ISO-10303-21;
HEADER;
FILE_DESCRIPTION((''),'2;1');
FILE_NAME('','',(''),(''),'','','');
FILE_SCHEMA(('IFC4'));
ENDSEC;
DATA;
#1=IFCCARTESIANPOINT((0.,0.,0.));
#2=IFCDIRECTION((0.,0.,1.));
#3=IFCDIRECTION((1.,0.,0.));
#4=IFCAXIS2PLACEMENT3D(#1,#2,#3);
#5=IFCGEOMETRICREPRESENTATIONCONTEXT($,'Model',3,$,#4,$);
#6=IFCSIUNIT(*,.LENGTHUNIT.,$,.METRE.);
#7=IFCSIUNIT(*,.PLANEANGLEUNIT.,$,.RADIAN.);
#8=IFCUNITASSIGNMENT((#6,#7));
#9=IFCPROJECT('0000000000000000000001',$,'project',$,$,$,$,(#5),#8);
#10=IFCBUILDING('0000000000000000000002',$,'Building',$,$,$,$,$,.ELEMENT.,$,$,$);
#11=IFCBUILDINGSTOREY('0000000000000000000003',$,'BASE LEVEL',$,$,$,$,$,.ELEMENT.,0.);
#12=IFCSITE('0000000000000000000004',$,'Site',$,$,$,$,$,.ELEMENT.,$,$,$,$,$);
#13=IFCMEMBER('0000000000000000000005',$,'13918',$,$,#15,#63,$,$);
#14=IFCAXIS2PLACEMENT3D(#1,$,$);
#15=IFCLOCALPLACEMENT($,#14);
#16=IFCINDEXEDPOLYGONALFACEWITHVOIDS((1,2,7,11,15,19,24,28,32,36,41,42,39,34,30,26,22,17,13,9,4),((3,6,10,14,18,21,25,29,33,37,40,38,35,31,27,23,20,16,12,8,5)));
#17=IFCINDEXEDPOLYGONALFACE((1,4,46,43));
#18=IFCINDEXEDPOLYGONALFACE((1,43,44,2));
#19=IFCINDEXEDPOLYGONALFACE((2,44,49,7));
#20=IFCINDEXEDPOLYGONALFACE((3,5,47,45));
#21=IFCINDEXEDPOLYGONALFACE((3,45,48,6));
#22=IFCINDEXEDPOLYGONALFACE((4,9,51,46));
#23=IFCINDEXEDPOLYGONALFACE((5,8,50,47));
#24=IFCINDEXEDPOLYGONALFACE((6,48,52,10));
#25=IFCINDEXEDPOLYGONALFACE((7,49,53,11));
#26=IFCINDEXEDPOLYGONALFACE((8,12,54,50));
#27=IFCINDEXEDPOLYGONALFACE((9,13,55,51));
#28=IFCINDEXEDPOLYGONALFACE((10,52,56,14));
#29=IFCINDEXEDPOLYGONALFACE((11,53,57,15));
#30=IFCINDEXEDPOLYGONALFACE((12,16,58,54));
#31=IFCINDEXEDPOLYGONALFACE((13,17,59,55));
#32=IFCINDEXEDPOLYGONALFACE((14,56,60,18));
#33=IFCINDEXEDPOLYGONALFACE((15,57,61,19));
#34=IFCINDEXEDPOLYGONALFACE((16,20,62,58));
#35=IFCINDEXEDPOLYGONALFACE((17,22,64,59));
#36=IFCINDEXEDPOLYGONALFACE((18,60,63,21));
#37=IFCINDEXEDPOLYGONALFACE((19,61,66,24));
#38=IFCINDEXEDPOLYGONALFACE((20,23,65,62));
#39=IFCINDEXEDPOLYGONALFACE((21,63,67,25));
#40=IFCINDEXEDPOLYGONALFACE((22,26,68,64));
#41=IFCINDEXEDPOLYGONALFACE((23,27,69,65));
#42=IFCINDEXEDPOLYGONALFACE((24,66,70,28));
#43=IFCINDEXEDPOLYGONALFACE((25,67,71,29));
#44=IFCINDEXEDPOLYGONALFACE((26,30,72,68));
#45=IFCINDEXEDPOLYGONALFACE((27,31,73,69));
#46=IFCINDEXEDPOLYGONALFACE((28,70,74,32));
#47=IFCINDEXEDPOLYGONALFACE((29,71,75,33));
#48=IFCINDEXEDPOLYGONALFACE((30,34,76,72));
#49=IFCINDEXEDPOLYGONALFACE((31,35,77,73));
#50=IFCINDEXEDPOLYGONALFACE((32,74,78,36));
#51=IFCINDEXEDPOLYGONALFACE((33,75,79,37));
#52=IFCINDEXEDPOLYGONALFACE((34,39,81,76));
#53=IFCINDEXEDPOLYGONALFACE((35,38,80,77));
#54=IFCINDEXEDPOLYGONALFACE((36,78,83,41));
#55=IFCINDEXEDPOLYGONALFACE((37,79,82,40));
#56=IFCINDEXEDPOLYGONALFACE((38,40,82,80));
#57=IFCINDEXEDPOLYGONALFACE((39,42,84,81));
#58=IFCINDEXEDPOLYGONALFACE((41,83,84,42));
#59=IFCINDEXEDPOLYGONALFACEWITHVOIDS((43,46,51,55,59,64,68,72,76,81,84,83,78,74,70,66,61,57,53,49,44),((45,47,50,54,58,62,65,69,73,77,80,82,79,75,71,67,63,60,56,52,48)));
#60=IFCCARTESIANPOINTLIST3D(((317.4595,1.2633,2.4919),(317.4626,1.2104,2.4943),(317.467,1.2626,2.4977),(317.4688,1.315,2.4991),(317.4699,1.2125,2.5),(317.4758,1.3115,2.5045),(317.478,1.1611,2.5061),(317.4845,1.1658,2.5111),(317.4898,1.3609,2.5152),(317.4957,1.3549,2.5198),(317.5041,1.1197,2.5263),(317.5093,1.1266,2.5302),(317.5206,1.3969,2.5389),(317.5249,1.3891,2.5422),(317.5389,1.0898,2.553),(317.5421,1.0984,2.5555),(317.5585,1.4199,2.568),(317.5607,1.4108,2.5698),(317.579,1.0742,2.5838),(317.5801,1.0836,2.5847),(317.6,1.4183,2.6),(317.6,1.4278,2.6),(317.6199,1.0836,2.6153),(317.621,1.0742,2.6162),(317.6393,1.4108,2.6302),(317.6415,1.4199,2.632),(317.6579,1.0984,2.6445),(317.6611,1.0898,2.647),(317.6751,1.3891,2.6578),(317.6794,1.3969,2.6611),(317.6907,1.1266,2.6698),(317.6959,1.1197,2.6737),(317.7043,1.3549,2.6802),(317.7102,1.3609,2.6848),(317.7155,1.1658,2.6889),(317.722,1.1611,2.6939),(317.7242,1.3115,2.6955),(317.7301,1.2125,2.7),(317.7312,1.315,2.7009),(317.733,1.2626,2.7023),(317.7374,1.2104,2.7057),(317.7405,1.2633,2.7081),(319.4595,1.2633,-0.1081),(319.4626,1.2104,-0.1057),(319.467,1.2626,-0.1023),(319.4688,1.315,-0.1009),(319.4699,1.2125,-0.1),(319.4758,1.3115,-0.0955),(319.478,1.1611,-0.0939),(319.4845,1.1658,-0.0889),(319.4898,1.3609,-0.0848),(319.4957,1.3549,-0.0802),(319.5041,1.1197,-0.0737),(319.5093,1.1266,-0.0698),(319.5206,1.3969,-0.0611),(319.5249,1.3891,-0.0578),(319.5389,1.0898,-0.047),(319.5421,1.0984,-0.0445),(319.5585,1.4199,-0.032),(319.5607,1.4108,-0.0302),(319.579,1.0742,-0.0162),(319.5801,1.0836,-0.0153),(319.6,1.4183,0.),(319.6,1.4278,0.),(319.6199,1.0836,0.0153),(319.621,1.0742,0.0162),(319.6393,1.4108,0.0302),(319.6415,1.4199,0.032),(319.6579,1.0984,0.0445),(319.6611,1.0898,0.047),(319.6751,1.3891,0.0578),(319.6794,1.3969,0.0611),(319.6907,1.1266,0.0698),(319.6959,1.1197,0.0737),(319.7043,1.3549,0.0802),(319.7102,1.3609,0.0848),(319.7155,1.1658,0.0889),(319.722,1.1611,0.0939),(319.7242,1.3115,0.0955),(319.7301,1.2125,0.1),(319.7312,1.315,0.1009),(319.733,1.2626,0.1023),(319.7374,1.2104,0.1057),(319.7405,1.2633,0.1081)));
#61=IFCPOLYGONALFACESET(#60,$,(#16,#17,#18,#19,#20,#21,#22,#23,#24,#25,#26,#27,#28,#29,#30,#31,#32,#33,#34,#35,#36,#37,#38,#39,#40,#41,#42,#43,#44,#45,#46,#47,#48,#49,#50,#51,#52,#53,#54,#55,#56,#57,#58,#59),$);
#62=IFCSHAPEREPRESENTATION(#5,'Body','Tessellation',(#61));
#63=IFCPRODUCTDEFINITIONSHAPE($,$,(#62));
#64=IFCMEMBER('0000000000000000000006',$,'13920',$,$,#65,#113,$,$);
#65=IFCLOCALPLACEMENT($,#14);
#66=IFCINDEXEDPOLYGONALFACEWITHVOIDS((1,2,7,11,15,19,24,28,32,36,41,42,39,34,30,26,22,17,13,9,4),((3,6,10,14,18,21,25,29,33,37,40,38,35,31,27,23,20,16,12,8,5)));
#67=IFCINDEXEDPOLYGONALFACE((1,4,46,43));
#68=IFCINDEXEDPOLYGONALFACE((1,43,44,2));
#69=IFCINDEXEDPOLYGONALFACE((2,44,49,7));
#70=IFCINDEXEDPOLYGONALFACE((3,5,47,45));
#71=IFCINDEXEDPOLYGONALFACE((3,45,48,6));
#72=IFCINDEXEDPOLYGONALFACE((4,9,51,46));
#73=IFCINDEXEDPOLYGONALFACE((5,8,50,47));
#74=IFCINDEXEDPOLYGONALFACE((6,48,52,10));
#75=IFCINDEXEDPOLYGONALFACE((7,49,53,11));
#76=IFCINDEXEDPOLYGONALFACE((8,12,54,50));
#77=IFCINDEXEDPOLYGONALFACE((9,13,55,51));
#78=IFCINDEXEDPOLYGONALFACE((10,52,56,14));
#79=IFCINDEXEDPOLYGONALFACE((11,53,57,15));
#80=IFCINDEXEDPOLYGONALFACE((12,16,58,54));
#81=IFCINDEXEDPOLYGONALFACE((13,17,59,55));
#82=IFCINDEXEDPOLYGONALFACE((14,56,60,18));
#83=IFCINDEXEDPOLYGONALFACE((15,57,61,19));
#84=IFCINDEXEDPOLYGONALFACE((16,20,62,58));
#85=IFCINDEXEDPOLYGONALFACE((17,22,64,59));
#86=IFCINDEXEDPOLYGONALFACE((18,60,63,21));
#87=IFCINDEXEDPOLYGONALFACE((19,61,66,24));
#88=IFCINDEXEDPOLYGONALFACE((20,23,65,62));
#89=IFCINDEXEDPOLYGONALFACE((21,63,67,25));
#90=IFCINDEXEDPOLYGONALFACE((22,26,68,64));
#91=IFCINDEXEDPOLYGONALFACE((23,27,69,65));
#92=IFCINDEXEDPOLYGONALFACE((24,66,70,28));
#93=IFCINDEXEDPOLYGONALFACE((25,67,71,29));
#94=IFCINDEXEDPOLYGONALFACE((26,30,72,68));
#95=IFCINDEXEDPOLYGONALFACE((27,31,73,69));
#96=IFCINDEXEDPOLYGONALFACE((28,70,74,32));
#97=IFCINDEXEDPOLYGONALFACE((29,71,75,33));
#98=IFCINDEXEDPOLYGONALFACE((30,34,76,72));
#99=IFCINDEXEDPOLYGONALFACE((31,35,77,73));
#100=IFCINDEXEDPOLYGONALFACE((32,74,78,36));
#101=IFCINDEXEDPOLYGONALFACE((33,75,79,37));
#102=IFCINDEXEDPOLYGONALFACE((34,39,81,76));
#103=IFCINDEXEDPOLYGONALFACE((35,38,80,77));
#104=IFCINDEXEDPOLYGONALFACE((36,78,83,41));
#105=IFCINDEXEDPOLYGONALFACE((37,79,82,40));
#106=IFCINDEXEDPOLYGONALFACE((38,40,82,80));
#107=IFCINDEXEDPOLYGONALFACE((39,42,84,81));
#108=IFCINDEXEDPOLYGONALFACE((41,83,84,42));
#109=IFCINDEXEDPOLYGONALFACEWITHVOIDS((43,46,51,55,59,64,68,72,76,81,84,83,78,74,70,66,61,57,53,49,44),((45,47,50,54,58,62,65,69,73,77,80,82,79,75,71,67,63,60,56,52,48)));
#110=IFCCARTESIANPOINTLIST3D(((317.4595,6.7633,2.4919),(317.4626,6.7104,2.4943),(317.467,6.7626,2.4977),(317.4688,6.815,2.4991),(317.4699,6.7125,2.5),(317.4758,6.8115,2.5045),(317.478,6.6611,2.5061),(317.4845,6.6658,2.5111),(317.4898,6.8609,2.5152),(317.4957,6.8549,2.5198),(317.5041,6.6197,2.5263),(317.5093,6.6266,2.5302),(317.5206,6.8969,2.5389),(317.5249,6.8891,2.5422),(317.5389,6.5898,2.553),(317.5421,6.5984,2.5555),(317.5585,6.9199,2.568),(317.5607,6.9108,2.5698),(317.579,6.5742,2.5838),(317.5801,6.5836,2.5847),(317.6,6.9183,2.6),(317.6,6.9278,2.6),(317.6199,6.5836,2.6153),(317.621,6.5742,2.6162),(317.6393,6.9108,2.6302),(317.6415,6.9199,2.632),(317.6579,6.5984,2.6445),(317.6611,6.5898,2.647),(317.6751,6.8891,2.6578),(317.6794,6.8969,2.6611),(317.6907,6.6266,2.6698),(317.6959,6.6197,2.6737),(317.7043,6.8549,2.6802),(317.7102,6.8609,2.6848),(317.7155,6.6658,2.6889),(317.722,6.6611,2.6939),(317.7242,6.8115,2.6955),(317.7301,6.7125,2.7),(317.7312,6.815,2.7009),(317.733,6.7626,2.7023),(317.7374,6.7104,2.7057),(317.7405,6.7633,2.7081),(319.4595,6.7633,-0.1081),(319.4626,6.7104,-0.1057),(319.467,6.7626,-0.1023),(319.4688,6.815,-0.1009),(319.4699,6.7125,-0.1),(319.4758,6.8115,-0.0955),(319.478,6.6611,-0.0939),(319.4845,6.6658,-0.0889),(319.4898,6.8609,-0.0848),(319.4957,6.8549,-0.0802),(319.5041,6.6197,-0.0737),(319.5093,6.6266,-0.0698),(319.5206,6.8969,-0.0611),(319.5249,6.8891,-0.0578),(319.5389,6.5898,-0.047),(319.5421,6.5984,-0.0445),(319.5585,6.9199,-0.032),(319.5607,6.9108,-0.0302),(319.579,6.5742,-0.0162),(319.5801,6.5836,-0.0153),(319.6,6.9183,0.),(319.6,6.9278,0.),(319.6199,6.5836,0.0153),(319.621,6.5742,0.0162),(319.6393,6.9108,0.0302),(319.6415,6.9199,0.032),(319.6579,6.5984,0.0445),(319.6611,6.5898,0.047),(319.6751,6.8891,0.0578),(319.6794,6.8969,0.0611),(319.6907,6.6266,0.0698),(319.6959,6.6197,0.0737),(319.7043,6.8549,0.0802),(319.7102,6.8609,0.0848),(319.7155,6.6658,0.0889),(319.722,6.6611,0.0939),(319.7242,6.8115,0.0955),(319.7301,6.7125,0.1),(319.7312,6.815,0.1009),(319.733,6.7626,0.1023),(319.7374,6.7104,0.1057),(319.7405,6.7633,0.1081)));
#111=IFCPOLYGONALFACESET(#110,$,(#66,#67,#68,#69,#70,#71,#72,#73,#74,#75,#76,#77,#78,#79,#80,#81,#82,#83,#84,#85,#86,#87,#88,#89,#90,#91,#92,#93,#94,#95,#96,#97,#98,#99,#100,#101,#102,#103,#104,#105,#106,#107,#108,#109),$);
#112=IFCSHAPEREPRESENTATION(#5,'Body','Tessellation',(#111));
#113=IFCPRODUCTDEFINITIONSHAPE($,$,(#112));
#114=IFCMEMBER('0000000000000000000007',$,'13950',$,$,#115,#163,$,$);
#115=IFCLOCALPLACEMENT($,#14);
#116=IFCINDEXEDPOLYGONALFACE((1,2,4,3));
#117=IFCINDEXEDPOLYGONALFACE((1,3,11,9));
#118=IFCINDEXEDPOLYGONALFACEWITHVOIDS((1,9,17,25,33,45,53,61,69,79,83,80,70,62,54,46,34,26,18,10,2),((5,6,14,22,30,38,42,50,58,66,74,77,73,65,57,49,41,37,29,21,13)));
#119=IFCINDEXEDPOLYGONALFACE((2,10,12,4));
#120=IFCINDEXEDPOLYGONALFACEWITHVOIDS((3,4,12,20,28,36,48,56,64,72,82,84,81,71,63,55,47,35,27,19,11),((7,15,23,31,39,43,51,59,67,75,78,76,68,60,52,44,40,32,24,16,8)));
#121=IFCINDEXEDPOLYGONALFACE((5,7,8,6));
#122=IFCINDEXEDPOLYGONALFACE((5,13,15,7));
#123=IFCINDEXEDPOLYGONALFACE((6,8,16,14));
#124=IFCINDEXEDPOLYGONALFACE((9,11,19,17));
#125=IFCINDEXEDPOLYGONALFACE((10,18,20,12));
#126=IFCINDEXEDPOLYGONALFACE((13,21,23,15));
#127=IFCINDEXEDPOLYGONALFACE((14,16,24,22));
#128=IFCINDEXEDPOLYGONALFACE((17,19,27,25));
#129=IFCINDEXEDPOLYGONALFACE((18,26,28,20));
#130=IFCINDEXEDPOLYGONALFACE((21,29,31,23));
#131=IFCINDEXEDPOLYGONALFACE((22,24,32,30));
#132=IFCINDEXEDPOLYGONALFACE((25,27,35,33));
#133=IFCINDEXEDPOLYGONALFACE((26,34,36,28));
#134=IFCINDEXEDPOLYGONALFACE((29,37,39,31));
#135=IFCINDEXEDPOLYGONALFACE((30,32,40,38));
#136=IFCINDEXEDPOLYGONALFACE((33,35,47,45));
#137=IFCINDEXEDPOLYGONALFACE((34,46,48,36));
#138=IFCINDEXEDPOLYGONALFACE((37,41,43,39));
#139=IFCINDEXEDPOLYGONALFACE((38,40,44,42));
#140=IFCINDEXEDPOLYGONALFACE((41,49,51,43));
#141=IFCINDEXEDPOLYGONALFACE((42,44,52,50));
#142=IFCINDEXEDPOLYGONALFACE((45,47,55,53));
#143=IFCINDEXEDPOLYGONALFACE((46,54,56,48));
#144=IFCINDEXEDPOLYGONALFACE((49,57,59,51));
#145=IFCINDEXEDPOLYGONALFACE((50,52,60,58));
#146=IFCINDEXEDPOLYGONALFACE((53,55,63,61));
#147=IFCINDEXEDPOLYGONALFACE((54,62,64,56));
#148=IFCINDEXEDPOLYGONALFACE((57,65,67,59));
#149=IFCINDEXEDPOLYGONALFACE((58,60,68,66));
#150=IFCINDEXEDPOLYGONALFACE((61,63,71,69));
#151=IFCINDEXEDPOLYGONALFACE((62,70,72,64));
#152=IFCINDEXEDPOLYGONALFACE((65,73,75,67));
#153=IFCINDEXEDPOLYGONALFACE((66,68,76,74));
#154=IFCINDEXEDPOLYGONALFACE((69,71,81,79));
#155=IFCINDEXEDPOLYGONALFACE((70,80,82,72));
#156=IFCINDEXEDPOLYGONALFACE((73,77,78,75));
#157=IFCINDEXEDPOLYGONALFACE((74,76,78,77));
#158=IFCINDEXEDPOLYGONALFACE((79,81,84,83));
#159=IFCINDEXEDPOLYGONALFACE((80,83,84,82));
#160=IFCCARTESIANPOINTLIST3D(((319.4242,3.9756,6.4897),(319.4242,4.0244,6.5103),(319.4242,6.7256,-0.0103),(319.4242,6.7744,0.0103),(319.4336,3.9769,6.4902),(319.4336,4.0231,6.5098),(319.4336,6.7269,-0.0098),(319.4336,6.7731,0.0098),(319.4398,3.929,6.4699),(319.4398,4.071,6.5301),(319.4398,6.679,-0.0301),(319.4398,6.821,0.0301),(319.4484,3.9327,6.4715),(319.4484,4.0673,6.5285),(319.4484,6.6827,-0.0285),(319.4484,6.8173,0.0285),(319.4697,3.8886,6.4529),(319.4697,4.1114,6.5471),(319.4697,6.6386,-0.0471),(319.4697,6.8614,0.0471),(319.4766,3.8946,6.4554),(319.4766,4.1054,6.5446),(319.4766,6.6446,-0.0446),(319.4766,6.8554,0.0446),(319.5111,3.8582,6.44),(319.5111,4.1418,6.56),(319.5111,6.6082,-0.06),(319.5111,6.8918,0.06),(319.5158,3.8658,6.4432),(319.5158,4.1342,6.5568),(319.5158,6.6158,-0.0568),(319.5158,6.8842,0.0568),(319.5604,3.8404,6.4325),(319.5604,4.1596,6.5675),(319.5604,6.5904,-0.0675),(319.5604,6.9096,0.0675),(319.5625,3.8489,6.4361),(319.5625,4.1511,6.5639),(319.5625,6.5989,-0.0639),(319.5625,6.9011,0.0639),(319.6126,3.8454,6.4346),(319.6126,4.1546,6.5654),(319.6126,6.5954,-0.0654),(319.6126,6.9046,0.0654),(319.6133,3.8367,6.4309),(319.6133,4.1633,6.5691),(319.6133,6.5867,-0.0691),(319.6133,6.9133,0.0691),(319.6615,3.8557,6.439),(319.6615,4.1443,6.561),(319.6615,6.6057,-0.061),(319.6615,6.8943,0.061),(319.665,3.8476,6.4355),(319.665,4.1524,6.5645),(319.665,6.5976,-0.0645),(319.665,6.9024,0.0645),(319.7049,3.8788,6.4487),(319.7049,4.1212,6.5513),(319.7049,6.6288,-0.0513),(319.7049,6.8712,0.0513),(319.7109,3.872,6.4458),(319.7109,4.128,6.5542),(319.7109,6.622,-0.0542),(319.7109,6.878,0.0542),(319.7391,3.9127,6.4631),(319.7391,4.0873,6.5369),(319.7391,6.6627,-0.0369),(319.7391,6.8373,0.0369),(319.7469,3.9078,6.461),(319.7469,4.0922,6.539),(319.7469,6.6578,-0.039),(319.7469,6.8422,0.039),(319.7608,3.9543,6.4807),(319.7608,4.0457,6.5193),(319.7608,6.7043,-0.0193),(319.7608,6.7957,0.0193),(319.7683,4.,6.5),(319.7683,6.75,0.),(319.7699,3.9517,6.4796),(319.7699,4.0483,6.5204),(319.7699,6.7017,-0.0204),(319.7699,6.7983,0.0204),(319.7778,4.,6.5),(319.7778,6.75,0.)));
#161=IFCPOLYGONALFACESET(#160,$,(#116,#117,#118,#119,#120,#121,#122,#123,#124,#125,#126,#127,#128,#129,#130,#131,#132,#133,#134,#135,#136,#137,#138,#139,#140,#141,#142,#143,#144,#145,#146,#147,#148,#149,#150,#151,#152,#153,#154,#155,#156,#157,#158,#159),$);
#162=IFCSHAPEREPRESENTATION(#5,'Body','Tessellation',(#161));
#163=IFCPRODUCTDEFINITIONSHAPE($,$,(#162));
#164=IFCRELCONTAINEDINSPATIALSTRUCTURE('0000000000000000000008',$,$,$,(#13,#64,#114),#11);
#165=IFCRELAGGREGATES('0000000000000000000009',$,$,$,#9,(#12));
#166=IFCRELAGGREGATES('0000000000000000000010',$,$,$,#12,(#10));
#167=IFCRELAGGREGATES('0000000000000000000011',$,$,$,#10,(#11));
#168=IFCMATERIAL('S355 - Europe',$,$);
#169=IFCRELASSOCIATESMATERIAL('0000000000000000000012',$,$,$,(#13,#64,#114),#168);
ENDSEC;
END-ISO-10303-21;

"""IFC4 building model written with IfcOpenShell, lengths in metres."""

from ifc_helpers import new_model, si_unit, frame, origin_with_axes, origin_2d_with_axis, place, context, project, spatial, hollow_circle, extrude, material, material_profile, profile_set, profile_usage, element, save


model = new_model("IFC4")

# Units and contexts
model_context = context("Model", 3, world=origin_with_axes())
ifc_project = project(units=[si_unit("LENGTHUNIT", "METRE"), si_unit("PLANEANGLEUNIT", "RADIAN")], contexts=[model_context])

# Site, building, storey
site = spatial("IfcSite", under=ifc_project, Name="Site", CompositionType="ELEMENT")
building = spatial("IfcBuilding", under=site, Name="Building", CompositionType="ELEMENT")
storey = spatial("IfcBuildingStorey", under=building, Name="BASE LEVEL", CompositionType="ELEMENT", Elevation=0.0)

# Shared definitions
ifc_material = material(Name="S355 - Europe")

# Members
ifc_material_profile_1 = material_profile(ifc_material, hollow_circle(Radius=0.1778, WallThickness=0.0095, at=origin_2d_with_axis()))
ifc_profile_set_1 = profile_set([ifc_material_profile_1])
ifc_profile_usage_1 = profile_usage(ifc_profile_set_1, cardinal=10)
member_1_placement = place(None, frame((317.6, 1.25, 2.6), z_axis=(0.609711, 0.0, -0.792624), x_axis=(0.0, 1.0, 0.0)))
element("IfcMember", 1, at=member_1_placement, inside=storey, material=ifc_profile_usage_1, Name="13918", context=model_context, shape_type="SweptSolid", body=[
    extrude(hollow_circle(Radius=0.1778, WallThickness=0.0095, at=origin_2d_with_axis()), origin_with_axes(), (0.0, 0.0, 1.0), 3.2802),
])
ifc_material_profile_2 = material_profile(ifc_material, hollow_circle(Radius=0.1778, WallThickness=0.0095, at=origin_2d_with_axis()))
ifc_profile_set_2 = profile_set([ifc_material_profile_2])
ifc_profile_usage_2 = profile_usage(ifc_profile_set_2, cardinal=10)
member_2_placement = place(None, frame((317.6, 6.75, 2.6), z_axis=(0.609711, 0.0, -0.792624), x_axis=(0.0, 1.0, 0.0)))
element("IfcMember", 2, at=member_2_placement, inside=storey, material=ifc_profile_usage_2, Name="13920", context=model_context, shape_type="SweptSolid", body=[
    extrude(hollow_circle(Radius=0.1778, WallThickness=0.0095, at=origin_2d_with_axis()), origin_with_axes(), (0.0, 0.0, 1.0), 3.2802),
])
ifc_material_profile_3 = material_profile(ifc_material, hollow_circle(Radius=0.1778, WallThickness=0.0095, at=origin_2d_with_axis()))
ifc_profile_set_3 = profile_set([ifc_material_profile_3])
ifc_profile_usage_3 = profile_usage(ifc_profile_set_3, cardinal=10)
member_3_placement = place(None, frame((319.6, 6.75, 0.0), z_axis=(0.0, -0.38964, 0.920967), x_axis=(1.0, 0.0, 0.0)))
element("IfcMember", 3, at=member_3_placement, inside=storey, material=ifc_profile_usage_3, Name="13950", context=model_context, shape_type="SweptSolid", body=[
    extrude(hollow_circle(Radius=0.1778, WallThickness=0.0095, at=origin_2d_with_axis()), origin_with_axes(), (0.0, 0.0, 1.0), 7.0578),
])

save(model, "model.ifc")
